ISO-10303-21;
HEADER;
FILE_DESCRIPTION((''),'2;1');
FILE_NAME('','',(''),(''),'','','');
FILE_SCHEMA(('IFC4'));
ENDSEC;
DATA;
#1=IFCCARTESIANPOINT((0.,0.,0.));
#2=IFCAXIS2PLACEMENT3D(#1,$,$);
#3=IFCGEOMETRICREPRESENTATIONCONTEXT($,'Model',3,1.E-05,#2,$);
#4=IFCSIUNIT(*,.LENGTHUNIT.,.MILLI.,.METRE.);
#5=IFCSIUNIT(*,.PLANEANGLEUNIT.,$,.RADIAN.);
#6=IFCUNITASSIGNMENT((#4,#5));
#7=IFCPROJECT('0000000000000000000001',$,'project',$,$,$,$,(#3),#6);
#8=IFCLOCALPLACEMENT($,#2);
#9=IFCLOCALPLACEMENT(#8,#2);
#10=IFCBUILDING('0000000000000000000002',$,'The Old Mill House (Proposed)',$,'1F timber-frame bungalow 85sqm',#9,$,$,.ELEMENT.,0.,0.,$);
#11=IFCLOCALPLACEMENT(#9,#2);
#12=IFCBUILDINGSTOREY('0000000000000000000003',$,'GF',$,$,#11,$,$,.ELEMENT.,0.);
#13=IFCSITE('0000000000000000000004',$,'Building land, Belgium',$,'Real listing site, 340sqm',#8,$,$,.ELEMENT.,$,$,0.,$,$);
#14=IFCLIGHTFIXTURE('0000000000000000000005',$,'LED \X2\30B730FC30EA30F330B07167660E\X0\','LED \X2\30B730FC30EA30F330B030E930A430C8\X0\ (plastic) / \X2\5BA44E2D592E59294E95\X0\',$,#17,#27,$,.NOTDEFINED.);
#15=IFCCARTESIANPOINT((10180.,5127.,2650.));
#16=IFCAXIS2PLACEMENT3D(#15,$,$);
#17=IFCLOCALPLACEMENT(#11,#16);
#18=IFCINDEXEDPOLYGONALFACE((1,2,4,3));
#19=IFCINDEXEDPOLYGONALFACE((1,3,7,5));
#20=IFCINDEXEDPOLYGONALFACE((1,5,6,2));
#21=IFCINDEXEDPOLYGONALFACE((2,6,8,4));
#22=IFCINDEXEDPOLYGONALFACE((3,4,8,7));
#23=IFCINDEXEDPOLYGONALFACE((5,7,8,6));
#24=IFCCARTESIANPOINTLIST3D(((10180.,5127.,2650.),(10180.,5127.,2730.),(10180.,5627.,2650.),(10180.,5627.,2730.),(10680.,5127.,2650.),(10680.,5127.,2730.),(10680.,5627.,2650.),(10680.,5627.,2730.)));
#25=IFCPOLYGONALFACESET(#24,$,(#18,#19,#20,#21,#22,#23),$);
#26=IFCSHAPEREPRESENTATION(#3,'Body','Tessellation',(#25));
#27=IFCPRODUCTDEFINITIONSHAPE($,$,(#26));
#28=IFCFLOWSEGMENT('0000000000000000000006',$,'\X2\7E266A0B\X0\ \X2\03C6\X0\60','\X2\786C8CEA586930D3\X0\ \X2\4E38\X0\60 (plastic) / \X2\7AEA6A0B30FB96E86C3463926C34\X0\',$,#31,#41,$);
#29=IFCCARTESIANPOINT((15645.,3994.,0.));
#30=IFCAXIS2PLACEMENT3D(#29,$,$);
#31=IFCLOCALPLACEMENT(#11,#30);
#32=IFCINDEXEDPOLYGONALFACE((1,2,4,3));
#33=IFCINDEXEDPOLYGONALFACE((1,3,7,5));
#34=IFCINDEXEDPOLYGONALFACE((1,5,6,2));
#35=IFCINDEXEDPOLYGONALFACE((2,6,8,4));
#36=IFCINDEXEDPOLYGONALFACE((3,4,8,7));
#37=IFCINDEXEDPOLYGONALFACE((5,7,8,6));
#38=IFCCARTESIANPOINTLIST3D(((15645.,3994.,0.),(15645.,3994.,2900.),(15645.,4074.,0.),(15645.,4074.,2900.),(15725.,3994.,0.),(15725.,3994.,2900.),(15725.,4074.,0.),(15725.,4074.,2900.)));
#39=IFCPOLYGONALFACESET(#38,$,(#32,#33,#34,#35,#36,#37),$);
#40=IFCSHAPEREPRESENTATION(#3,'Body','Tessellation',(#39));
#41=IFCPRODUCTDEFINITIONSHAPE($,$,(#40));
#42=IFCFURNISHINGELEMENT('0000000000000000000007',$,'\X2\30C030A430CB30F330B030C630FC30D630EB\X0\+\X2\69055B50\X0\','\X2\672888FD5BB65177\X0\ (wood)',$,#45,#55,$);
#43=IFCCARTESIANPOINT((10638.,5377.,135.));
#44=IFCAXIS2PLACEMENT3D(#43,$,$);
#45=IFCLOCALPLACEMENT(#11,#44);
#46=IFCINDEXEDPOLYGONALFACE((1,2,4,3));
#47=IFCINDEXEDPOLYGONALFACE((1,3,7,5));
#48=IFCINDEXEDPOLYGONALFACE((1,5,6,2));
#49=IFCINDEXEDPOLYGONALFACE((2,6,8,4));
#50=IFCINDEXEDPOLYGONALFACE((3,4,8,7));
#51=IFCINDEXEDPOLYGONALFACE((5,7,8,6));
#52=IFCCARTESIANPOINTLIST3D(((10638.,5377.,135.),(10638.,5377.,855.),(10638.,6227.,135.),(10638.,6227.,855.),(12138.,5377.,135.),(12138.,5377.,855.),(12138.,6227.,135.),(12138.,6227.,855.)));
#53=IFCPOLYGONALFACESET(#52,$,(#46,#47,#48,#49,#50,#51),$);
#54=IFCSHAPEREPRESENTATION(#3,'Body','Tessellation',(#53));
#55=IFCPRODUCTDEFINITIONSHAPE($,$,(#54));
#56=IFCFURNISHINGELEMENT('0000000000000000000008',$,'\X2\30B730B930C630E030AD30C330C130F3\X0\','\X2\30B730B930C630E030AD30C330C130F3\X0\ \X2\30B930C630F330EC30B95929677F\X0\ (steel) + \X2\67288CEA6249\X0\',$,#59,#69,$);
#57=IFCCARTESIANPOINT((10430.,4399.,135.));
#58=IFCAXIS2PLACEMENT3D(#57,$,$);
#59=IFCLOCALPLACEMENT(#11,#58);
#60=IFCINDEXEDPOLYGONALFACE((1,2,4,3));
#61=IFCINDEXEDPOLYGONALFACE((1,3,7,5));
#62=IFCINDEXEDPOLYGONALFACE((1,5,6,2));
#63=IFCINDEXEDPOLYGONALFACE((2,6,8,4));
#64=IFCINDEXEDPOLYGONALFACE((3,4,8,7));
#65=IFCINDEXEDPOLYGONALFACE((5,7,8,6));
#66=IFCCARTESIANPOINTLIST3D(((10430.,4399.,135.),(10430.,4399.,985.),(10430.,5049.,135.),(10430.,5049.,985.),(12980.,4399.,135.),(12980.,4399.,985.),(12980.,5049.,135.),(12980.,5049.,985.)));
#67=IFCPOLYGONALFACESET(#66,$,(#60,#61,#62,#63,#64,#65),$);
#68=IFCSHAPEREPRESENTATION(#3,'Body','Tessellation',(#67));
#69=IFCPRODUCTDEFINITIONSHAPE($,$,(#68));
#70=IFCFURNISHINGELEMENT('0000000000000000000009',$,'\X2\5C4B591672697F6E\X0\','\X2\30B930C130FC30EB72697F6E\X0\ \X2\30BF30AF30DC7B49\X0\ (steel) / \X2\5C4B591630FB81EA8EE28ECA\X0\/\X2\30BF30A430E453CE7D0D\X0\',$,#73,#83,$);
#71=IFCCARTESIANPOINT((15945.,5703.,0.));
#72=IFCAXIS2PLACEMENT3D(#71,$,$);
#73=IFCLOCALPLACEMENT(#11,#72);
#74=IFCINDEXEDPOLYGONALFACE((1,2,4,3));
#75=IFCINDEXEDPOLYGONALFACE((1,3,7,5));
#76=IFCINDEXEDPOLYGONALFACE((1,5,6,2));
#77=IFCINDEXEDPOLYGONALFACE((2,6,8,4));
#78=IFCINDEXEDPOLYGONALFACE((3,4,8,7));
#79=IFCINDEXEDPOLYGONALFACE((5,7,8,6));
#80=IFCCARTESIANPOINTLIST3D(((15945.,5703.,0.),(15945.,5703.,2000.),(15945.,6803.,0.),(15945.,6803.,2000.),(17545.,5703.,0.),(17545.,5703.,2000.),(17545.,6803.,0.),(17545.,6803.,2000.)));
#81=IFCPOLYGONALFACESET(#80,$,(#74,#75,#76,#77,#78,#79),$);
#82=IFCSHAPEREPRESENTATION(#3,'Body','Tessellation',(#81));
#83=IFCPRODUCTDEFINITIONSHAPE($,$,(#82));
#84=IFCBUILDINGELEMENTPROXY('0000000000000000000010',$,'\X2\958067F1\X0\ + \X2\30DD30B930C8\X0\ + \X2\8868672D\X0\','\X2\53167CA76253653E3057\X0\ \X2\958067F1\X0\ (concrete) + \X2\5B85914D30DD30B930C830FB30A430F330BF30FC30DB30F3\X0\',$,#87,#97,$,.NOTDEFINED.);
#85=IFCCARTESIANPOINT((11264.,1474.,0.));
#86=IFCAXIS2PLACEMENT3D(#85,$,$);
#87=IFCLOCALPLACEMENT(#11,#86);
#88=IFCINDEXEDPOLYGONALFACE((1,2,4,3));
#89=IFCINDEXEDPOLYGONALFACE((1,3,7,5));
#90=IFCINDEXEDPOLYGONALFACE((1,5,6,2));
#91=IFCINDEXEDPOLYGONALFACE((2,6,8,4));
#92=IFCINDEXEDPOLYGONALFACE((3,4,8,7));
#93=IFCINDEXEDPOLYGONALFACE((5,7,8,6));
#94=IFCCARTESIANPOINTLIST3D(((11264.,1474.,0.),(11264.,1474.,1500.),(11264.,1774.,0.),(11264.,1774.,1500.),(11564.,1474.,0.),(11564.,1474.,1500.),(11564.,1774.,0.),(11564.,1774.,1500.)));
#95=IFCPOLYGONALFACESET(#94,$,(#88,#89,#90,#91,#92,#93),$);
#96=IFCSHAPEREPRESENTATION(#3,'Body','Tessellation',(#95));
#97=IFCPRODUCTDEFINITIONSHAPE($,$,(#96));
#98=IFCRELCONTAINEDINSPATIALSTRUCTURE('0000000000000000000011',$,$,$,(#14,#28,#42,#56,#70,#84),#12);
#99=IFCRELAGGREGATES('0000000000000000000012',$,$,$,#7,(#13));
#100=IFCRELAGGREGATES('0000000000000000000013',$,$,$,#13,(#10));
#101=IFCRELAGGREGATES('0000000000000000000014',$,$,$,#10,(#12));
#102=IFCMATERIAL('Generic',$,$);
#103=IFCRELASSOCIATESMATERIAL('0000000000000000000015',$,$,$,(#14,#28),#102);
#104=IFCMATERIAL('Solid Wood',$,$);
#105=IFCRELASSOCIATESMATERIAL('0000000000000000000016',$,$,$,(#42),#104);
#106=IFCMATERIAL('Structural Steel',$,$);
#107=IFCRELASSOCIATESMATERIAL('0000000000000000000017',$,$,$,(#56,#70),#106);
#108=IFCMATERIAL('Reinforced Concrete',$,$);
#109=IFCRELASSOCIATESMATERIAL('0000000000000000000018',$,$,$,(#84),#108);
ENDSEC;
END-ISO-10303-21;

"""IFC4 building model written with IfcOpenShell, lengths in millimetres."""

from ifc_helpers import new_model, si_unit, frame, frame_2d, origin, place, context, project, spatial, rectangle, extrude, material, element, save


model = new_model("IFC4")

# Units and contexts
model_context = context("Model", 3, precision=1e-05, world=origin())
ifc_project = project(units=[si_unit("LENGTHUNIT", "METRE", prefix="MILLI"), si_unit("PLANEANGLEUNIT", "RADIAN")], contexts=[model_context])

# Site, building, storey
site_placement = place(None, origin())
site = spatial("IfcSite", under=ifc_project, at=site_placement, Name="Building land, Belgium", ObjectType="Real listing site, 340sqm", CompositionType="ELEMENT", RefElevation=0.0)
building_placement = place(site_placement, origin())
building = spatial("IfcBuilding", under=site, at=building_placement, Name="The Old Mill House (Proposed)", ObjectType="1F timber-frame bungalow 85sqm", CompositionType="ELEMENT", ElevationOfRefHeight=0.0, ElevationOfTerrain=0.0)
storey_placement = place(building_placement, origin())
storey = spatial("IfcBuildingStorey", under=building, at=storey_placement, Name="GF", CompositionType="ELEMENT", Elevation=0.0)

# Shared definitions
ifc_material_1 = material(Name="Solid Wood")

# Shared definitions
ifc_material_2 = material(Name="Structural Steel")

# Shared definitions
ifc_material_3 = material(Name="Reinforced Concrete")

# Shared definitions
ifc_material_4 = material(Name="Generic")

# Light fixture
light_fixture_placement = place(storey_placement, frame((10180.0, 5127.0, 2650.0)))
element("IfcLightFixture", 1, at=light_fixture_placement, inside=storey, material=ifc_material_4, Name="LED シーリング照明", Description="LED シーリングライト (plastic) / 室中央天井", PredefinedType="NOTDEFINED", context=model_context, shape_type="SweptSolid", body=[
    extrude(rectangle(XDim=500.0, YDim=500.0, at=frame_2d((250.0, 250.0))), frame((10180.0, 5127.0, 2650.0)), (0.0, 0.0, 1.0), 80.0),
])

# Flow segment
flow_segment_placement = place(storey_placement, frame((15645.0, 3994.0, 0.0)))
element("IfcFlowSegment", 2, at=flow_segment_placement, inside=storey, material=ifc_material_4, Name="縦樋 φ60", Description="硬質塩ビ 丸60 (plastic) / 竪樋・雨水排水", context=model_context, shape_type="SweptSolid", body=[
    extrude(rectangle(XDim=80.0, YDim=80.0, at=frame_2d((40.0, 40.0))), frame((15645.0, 3994.0, 0.0)), (0.0, 0.0, 1.0), 2900.0),
])

# Furnishing elements
furnishing_1_placement = place(storey_placement, frame((10638.0, 5377.0, 135.0)))
element("IfcFurnishingElement", 3, at=furnishing_1_placement, inside=storey, material=ifc_material_1, Name="ダイニングテーブル+椅子", Description="木製家具 (wood)", context=model_context, shape_type="SweptSolid", body=[
    extrude(rectangle(XDim=1500.0, YDim=850.0, at=frame_2d((750.0, 425.0))), frame((10638.0, 5377.0, 135.0)), (0.0, 0.0, 1.0), 720.0),
])
furnishing_2_placement = place(storey_placement, frame((10430.0, 4399.0, 135.0)))
element("IfcFurnishingElement", 4, at=furnishing_2_placement, inside=storey, material=ifc_material_2, Name="システムキッチン", Description="システムキッチン ステンレス天板 (steel) + 木質扉", context=model_context, shape_type="SweptSolid", body=[
    extrude(rectangle(XDim=2550.0, YDim=650.0, at=frame_2d((1275.0, 325.0))), frame((10430.0, 4399.0, 135.0)), (0.0, 0.0, 1.0), 850.0),
])
furnishing_3_placement = place(storey_placement, frame((15945.0, 5703.0, 0.0)))
element("IfcFurnishingElement", 5, at=furnishing_3_placement, inside=storey, material=ifc_material_2, Name="屋外物置", Description="スチール物置 タクボ等 (steel) / 屋外・自転車/タイヤ収納", context=model_context, shape_type="SweptSolid", body=[
    extrude(rectangle(XDim=1600.0, YDim=1100.0, at=frame_2d((800.0, 550.0))), frame((15945.0, 5703.0, 0.0)), (0.0, 0.0, 1.0), 2000.0),
])

# Building element proxy
proxy_placement = place(storey_placement, frame((11264.0, 1474.0, 0.0)))
element("IfcBuildingElementProxy", 6, at=proxy_placement, inside=storey, material=ifc_material_3, Name="門柱 + ポスト + 表札", Description="化粧打放し 門柱 (concrete) + 宅配ポスト・インターホン", PredefinedType="NOTDEFINED", context=model_context, shape_type="SweptSolid", body=[
    extrude(rectangle(XDim=300.0, YDim=300.0, at=frame_2d((150.0, 150.0))), frame((11264.0, 1474.0, 0.0)), (0.0, 0.0, 1.0), 1500.0),
])

save(model, "model.ifc")
